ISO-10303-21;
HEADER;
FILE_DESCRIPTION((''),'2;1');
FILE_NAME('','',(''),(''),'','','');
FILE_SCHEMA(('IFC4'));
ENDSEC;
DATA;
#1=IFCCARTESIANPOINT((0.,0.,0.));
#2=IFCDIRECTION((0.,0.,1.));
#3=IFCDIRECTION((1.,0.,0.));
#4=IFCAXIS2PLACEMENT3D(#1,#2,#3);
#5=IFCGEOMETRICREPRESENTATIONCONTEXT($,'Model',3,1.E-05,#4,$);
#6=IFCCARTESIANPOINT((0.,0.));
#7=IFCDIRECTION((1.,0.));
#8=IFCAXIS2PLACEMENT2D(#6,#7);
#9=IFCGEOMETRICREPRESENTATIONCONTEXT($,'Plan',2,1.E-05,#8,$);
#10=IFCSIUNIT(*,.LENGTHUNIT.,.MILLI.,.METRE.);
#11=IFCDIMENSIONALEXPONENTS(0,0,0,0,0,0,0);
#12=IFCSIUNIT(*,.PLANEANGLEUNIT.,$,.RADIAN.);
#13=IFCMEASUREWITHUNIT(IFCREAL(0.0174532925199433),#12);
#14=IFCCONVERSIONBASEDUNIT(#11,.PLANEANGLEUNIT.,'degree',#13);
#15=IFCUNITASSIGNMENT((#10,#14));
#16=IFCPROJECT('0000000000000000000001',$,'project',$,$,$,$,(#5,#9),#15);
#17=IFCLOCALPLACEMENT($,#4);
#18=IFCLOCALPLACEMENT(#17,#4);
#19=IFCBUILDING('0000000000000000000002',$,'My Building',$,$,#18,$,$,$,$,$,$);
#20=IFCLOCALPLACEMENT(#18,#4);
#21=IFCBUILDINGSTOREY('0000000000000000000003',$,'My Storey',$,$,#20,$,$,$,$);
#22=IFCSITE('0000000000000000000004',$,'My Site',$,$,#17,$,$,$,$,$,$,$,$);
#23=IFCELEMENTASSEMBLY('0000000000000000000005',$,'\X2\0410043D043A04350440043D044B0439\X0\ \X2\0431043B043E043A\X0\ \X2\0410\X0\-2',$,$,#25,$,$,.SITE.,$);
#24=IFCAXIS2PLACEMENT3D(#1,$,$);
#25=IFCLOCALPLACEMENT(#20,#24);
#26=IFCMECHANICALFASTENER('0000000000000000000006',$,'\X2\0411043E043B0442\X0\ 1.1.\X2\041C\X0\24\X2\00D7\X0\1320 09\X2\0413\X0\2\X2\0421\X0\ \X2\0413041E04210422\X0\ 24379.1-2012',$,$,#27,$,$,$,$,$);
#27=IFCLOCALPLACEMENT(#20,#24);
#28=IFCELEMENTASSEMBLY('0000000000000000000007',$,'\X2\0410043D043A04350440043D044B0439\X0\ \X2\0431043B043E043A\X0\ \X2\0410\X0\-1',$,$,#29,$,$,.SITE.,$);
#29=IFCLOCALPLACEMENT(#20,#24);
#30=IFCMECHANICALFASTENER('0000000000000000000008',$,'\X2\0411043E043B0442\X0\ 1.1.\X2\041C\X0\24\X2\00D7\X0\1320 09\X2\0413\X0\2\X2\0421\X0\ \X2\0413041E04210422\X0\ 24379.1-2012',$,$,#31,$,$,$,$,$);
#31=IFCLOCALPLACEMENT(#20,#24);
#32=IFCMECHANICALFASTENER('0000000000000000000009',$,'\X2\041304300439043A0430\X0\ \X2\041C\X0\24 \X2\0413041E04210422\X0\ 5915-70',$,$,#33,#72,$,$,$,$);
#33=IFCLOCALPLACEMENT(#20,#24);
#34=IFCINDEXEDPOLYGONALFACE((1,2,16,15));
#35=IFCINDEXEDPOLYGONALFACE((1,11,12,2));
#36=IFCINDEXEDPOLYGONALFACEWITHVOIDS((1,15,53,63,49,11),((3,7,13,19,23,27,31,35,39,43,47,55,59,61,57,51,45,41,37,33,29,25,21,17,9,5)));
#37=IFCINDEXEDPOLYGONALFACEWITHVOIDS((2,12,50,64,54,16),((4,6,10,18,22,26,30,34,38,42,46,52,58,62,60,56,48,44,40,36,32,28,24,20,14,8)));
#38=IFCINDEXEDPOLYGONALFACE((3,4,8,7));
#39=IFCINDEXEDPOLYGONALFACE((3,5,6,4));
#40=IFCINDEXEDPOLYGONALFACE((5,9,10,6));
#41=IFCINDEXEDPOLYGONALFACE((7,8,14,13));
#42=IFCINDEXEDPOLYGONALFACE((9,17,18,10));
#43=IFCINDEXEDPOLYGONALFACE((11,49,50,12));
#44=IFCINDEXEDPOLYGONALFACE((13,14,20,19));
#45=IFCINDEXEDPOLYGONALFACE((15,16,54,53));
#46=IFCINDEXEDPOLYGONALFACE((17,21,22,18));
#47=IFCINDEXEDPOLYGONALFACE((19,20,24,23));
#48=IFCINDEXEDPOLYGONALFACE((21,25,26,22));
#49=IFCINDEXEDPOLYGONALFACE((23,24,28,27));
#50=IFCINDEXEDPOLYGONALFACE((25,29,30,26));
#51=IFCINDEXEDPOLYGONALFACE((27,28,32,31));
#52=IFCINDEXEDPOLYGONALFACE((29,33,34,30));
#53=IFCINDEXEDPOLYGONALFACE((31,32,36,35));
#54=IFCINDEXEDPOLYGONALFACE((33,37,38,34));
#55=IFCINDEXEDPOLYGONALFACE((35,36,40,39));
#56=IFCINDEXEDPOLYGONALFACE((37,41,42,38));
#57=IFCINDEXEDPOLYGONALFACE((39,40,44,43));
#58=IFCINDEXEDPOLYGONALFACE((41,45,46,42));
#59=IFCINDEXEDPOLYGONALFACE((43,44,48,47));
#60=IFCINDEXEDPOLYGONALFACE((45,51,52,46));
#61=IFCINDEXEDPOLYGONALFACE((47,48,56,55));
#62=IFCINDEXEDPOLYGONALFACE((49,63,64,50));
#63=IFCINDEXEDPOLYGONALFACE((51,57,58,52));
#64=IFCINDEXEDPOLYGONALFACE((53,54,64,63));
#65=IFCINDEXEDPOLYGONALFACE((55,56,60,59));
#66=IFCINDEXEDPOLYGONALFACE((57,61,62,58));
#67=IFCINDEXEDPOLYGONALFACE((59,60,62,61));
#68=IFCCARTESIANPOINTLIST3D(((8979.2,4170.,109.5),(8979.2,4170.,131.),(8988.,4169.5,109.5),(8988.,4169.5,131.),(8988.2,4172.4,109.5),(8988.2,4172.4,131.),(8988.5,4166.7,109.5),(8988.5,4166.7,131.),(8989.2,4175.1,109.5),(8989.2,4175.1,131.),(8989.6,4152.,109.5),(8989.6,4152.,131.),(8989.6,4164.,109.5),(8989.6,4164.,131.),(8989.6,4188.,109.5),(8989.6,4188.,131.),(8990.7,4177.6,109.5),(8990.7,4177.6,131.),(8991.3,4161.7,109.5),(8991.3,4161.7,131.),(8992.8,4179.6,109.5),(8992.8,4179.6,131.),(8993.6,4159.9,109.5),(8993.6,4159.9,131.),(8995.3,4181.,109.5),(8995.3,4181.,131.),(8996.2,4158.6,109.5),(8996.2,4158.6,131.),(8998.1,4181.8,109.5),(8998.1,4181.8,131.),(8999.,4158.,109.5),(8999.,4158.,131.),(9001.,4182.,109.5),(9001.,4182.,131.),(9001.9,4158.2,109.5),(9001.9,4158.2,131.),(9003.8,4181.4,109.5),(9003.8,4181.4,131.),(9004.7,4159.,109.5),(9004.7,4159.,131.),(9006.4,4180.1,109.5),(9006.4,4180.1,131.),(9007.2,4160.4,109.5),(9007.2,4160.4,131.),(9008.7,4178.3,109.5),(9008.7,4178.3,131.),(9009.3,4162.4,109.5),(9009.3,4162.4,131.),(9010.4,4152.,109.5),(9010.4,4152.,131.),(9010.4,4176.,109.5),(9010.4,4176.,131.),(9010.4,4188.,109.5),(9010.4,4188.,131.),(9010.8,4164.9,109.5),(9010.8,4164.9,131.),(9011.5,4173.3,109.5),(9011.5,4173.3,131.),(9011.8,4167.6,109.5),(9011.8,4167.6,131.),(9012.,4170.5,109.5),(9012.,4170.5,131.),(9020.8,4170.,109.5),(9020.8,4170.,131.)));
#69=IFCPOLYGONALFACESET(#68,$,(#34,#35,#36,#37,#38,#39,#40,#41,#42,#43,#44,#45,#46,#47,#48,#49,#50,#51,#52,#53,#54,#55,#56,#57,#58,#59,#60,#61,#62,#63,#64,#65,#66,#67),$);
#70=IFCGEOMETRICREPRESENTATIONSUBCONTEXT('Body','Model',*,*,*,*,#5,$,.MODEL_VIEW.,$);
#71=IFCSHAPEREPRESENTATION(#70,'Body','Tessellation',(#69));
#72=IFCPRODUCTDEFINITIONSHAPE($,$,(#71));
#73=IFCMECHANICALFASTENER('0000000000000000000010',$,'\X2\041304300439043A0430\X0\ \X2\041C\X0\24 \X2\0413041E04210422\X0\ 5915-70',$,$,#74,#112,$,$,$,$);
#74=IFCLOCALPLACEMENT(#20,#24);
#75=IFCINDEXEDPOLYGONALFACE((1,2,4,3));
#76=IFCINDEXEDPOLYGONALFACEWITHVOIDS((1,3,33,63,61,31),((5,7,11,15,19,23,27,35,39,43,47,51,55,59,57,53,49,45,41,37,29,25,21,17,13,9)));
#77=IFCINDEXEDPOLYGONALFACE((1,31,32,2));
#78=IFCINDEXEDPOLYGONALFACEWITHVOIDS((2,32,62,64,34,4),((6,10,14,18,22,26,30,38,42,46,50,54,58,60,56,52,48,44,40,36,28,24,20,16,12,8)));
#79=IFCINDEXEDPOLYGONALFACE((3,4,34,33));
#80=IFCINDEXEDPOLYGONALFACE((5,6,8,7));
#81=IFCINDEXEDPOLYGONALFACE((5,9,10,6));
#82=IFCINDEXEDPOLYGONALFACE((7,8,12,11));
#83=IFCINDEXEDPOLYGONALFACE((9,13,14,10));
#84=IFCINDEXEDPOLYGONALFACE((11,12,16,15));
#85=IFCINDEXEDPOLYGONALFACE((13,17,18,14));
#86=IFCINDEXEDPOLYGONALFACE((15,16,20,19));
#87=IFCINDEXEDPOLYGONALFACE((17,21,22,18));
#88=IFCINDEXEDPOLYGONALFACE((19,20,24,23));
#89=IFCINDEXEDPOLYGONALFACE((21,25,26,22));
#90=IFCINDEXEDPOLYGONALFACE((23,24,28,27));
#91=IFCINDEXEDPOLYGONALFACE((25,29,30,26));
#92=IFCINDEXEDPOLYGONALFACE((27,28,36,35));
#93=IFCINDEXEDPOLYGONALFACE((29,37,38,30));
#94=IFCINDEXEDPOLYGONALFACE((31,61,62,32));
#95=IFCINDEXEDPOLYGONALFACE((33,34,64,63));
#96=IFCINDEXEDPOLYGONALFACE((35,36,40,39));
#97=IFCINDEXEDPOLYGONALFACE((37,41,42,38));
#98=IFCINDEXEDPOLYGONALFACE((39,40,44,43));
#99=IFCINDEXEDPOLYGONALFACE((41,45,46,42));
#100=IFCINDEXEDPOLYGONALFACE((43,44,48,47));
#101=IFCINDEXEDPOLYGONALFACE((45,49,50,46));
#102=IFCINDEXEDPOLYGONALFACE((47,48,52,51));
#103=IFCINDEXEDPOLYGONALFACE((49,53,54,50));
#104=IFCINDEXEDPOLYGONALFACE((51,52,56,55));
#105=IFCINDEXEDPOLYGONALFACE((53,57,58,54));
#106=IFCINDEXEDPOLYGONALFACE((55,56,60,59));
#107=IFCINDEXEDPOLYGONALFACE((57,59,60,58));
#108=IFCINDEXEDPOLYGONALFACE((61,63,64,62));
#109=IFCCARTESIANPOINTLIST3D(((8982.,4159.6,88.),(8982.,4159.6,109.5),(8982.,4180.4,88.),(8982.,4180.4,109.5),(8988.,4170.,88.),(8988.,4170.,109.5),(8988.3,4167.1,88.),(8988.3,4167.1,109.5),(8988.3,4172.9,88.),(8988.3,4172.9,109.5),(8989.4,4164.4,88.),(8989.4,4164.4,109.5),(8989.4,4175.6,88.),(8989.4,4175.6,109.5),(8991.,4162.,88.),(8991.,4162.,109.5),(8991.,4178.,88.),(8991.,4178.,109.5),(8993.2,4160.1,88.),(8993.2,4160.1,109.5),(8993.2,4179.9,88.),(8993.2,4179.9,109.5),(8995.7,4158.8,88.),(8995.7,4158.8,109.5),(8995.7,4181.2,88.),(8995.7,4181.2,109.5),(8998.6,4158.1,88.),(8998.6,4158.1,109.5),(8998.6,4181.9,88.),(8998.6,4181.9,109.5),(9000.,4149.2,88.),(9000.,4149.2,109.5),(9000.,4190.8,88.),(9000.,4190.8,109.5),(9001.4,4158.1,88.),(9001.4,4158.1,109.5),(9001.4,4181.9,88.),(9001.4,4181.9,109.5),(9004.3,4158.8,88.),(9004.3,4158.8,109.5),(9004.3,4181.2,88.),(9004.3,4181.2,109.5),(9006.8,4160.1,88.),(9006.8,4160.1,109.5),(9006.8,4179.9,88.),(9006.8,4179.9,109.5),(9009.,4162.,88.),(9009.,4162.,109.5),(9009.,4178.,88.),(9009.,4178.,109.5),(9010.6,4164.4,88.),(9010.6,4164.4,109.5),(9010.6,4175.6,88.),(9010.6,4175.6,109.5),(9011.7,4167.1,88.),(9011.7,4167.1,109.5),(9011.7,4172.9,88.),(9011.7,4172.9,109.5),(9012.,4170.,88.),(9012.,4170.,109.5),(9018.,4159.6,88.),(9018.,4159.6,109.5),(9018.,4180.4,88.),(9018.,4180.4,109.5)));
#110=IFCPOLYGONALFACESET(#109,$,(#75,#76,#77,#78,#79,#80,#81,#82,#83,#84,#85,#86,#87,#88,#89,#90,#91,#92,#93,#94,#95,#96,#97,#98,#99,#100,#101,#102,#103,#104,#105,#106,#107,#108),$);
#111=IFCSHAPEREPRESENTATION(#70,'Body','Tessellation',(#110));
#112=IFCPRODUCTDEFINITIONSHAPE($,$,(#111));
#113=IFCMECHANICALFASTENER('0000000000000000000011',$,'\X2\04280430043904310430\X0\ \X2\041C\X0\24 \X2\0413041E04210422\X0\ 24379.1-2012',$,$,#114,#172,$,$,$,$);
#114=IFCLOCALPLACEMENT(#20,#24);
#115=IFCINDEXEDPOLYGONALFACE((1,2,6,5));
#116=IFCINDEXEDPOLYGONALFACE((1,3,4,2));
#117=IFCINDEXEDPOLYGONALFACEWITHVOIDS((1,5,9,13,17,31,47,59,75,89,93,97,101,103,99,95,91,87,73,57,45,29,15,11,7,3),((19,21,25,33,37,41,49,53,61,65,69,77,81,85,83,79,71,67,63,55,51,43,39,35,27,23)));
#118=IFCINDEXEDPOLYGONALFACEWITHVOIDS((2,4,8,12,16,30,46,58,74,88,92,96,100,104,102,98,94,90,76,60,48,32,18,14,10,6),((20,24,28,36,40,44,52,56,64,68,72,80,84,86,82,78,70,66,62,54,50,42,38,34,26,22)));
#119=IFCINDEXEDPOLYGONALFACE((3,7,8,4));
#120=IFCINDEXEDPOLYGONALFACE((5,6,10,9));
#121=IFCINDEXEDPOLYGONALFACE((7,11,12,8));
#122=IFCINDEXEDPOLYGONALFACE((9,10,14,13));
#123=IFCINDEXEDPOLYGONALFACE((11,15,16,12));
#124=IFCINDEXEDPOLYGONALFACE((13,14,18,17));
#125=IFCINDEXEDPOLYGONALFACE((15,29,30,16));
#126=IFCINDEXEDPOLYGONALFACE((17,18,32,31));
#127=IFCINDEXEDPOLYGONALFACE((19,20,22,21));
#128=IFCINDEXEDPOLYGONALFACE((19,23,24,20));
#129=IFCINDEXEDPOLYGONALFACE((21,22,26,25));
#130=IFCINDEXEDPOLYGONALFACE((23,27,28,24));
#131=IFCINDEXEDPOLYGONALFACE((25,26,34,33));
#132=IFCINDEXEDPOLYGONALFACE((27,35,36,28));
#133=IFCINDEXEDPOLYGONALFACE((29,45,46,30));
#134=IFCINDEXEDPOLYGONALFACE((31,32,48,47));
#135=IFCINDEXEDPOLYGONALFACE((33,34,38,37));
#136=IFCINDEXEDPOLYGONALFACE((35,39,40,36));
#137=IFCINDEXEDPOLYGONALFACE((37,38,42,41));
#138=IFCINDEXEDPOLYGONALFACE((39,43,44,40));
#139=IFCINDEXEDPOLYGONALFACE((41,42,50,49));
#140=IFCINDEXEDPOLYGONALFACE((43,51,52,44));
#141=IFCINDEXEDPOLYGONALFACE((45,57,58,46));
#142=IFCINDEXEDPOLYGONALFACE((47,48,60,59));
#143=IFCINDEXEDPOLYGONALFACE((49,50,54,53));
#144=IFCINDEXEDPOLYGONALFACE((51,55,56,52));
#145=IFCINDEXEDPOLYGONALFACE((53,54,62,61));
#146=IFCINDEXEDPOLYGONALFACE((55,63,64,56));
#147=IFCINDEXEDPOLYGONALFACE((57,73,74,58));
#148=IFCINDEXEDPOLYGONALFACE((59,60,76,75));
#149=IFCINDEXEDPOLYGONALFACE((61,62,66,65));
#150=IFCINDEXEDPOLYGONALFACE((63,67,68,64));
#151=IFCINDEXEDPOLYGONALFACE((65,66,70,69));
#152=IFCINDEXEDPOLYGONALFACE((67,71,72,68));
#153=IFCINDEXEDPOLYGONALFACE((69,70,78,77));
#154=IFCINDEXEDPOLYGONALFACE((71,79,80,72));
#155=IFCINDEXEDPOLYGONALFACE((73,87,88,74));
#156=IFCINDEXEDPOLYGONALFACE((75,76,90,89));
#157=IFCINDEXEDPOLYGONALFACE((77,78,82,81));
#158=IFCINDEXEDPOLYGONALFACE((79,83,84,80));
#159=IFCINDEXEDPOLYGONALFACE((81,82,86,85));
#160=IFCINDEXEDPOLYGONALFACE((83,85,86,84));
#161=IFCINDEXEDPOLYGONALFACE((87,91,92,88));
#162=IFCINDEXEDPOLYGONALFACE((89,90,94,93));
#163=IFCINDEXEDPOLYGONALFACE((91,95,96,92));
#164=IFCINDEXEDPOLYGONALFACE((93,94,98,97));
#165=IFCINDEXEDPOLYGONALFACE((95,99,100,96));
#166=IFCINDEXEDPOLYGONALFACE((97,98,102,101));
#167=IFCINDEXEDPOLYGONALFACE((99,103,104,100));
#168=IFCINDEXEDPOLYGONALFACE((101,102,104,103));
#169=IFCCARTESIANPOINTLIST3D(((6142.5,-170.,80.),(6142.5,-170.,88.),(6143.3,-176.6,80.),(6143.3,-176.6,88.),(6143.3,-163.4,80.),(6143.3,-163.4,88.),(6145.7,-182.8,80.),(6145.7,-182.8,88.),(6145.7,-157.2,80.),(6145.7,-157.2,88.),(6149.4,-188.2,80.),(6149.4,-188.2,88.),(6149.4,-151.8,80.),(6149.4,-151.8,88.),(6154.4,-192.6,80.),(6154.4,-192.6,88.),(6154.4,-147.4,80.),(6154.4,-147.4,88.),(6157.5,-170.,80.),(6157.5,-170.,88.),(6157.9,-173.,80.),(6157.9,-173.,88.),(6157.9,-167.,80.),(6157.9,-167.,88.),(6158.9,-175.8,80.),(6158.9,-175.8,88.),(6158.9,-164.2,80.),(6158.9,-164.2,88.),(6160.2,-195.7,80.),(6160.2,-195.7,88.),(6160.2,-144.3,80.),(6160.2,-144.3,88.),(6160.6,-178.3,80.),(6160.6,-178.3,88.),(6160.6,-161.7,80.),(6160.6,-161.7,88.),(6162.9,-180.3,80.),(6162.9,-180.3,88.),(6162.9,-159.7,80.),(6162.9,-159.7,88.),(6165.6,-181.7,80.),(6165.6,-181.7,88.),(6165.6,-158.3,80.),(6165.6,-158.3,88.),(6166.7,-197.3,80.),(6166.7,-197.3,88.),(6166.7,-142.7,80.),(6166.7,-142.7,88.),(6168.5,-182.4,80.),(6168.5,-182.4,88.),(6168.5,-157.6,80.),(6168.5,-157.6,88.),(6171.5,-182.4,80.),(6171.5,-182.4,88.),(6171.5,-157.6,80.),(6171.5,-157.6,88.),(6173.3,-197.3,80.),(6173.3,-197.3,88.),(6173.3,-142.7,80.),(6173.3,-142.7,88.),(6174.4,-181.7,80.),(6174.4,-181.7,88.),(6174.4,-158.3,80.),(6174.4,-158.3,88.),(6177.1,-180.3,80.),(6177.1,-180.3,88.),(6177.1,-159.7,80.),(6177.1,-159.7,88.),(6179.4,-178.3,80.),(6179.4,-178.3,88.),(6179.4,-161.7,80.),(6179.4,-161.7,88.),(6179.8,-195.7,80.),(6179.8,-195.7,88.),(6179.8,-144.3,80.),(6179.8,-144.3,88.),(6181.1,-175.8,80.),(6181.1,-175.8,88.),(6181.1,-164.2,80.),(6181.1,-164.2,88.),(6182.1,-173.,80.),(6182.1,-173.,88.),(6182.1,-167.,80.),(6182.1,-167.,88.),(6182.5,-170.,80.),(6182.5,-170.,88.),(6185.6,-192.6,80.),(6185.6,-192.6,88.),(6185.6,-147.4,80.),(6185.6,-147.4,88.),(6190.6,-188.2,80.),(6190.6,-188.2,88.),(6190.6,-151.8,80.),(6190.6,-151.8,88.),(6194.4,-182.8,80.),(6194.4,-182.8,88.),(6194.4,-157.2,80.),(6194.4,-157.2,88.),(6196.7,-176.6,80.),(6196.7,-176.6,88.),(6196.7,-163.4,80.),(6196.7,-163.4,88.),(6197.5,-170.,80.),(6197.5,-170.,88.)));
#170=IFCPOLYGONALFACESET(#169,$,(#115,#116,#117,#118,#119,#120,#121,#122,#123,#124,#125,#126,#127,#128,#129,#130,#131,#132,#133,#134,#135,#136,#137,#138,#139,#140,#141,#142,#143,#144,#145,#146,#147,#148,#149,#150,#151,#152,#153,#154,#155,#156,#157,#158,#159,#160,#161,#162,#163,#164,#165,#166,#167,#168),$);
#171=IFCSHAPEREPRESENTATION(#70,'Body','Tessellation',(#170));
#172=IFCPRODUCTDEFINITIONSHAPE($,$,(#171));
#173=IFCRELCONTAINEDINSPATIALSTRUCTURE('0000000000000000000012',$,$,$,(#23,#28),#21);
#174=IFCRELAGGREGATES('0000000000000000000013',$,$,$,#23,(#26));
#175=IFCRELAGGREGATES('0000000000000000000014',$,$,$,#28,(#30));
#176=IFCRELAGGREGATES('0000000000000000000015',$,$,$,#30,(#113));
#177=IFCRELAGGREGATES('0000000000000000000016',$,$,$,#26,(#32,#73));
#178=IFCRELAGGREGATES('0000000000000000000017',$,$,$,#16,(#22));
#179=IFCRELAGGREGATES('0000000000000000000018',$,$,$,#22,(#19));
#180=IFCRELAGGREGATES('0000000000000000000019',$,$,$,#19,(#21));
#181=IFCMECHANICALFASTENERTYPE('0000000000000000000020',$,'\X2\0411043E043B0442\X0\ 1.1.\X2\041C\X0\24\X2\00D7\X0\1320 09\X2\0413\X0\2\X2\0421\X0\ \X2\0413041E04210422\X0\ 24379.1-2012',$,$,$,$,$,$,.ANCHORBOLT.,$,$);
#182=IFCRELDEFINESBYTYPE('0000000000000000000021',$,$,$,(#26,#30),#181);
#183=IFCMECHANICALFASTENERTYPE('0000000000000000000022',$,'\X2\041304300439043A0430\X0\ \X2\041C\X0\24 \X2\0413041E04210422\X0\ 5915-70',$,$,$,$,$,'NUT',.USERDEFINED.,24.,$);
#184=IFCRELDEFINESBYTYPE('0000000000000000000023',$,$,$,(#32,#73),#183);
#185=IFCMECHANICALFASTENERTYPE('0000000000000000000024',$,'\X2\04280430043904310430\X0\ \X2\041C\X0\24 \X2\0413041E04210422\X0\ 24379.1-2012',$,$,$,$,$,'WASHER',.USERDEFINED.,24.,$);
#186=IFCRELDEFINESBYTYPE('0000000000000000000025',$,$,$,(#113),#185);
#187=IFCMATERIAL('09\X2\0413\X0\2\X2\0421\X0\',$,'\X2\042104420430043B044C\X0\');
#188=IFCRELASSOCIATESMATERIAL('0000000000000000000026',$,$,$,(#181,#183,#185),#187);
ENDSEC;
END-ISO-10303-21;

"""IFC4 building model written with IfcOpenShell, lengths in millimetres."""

from ifc_helpers import new_model, entity, si_unit, converted_unit, frame, origin_with_axes, origin_2d_with_axis, place, context, subcontext, project, spatial, polyline, outline, extrude, source, transform, mapped, material, type_object, type_shapes, element, aggregate, save


model = new_model("IFC4")

# Units and contexts
model_context = context("Model", 3, precision=1e-05, world=origin_with_axes())
plan_context = context("Plan", 2, precision=1e-05, world=origin_2d_with_axis())
body_context = subcontext(model_context, "Body", "Model", "MODEL_VIEW")
ifc_project = project(units=[si_unit("LENGTHUNIT", "METRE", prefix="MILLI"), converted_unit("PLANEANGLEUNIT", "degree", entity("IfcReal", 0.0174532925199433), si_unit("PLANEANGLEUNIT", "RADIAN"), dimensions=[0, 0, 0, 0, 0, 0, 0])], contexts=[model_context, plan_context])

# Site, building, storey
site_placement = place(None, origin_with_axes())
site = spatial("IfcSite", under=ifc_project, at=site_placement, Name="My Site")
building_placement = place(site_placement, origin_with_axes())
building = spatial("IfcBuilding", under=site, at=building_placement, Name="My Building")
storey_placement = place(building_placement, origin_with_axes())
storey = spatial("IfcBuildingStorey", under=building, at=storey_placement, Name="My Storey")

# Element assemblies, mechanical fasteners
ifc_material_1 = material(Name="09Г2С", Category="Сталь")
mechanical_fastener_type_1 = type_object("IfcMechanicalFastenerType", Name="Болт 1.1.М24×1320 09Г2С ГОСТ 24379.1-2012", PredefinedType="ANCHORBOLT", material=ifc_material_1)
assembly_1_placement = place(storey_placement, frame((9000.0, 4000.0, 0.0), z_axis=(0.0, 0.0, 1.0), x_axis=(1.0, 0.0, 0.0)))
assembly_1 = element("IfcElementAssembly", 1, at=assembly_1_placement, inside=storey, Name="Анкерный блок А-2", AssemblyPlace="SITE")
mechanical_fastener_1_placement = place(assembly_1_placement, frame((0.0, 170.0, 0.0), z_axis=(0.0, 0.0, 1.0), x_axis=(-1.0, 0.0, 0.0)))
mechanical_fastener_1 = element("IfcMechanicalFastener", 2, at=mechanical_fastener_1_placement, type_object=mechanical_fastener_type_1, Name="Болт 1.1.М24×1320 09Г2С ГОСТ 24379.1-2012")
aggregate(assembly_1, [mechanical_fastener_1])
assembly_2_placement = place(storey_placement, frame((6000.0, 0.0, 0.0), z_axis=(0.0, 0.0, 1.0), x_axis=(1.0, 0.0, 0.0)))
assembly_2 = element("IfcElementAssembly", 3, at=assembly_2_placement, inside=storey, Name="Анкерный блок А-1", AssemblyPlace="SITE")
mechanical_fastener_2_placement = place(assembly_2_placement, frame((170.0, -170.0, 0.0), z_axis=(0.0, 0.0, 1.0), x_axis=(1.0, 0.0, 0.0)))
mechanical_fastener_2 = element("IfcMechanicalFastener", 4, at=mechanical_fastener_2_placement, type_object=mechanical_fastener_type_1, Name="Болт 1.1.М24×1320 09Г2С ГОСТ 24379.1-2012")
aggregate(assembly_2, [mechanical_fastener_2])
mechanical_fastener_type_2 = type_object("IfcMechanicalFastenerType", Name="Гайка М24 ГОСТ 5915-70", ElementType="NUT", NominalDiameter=24.0, PredefinedType="USERDEFINED", material=ifc_material_1)
shared_shape_1 = source(origin_with_axes(), body_context, "Body", "SweptSolid", [
    extrude(outline(polyline([(-10.4, -18.0), (10.4, -18.0), (20.8, 0.0), (10.4, 18.0), (-10.4, 18.0), (-20.8, 0.0), (-10.4, -18.0)]), holes=[polyline([(-8.0, 9.0), (-5.6, 10.6), (-2.9, 11.7), (0.0, 12.0), (2.9, 11.7), (5.6, 10.6), (8.0, 9.0), (9.9, 6.8), (11.2, 4.3), (11.9, 1.4), (11.9, -1.4), (11.2, -4.3), (9.9, -6.8), (8.0, -9.0), (5.6, -10.6), (2.9, -11.7), (0.0, -12.0), (-2.9, -11.7), (-5.6, -10.6), (-8.0, -9.0), (-9.9, -6.8), (-11.2, -4.3), (-11.9, -1.4), (-11.9, 1.4), (-11.2, 4.3), (-9.9, 6.8), (-8.0, 9.0)])]), frame((0.0, 0.0, 0.0), z_axis=(0.0, 0.0, 1.0), x_axis=(0.0, 1.0, 0.0)), (0.0, 0.0, 1.0), 21.5),
])
type_shapes(mechanical_fastener_type_2, [shared_shape_1])

# Mechanical fasteners
mechanical_fastener_3_placement = place(mechanical_fastener_1_placement, frame((0.0, 0.0, 109.5), z_axis=(0.0, 0.0, 1.0), x_axis=(0.866025, 0.5, 0.0)))
mechanical_fastener_3 = element("IfcMechanicalFastener", 5, at=mechanical_fastener_3_placement, type_object=mechanical_fastener_type_2, Name="Гайка М24 ГОСТ 5915-70", context=body_context, shape_type="MappedRepresentation", body=[
    mapped(shared_shape_1, transform((0.0, 0.0, 0.0), x_axis=(1.0, 0.0, 0.0), y_axis=(0.0, 1.0, 0.0), z_axis=(0.0, 0.0, 1.0), scale=1.0)),
])
mechanical_fastener_4_placement = place(mechanical_fastener_1_placement, frame((0.0, 0.0, 88.0), z_axis=(0.0, 0.0, 1.0), x_axis=(1.0, 0.0, 0.0)))
mechanical_fastener_4 = element("IfcMechanicalFastener", 6, at=mechanical_fastener_4_placement, type_object=mechanical_fastener_type_2, Name="Гайка М24 ГОСТ 5915-70", context=body_context, shape_type="MappedRepresentation", body=[
    mapped(shared_shape_1, transform((0.0, 0.0, 0.0), x_axis=(1.0, 0.0, 0.0), y_axis=(0.0, 1.0, 0.0), z_axis=(0.0, 0.0, 1.0), scale=1.0)),
])
mechanical_fastener_type_3 = type_object("IfcMechanicalFastenerType", Name="Шайба М24 ГОСТ 24379.1-2012", ElementType="WASHER", NominalDiameter=24.0, PredefinedType="USERDEFINED", material=ifc_material_1)
shared_shape_2 = source(origin_with_axes(), body_context, "Body", "SweptSolid", [
    extrude(outline(polyline([(27.5, 0.0), (26.7, 6.6), (24.4, 12.8), (20.6, 18.2), (15.6, 22.6), (9.8, 25.7), (3.3, 27.3), (-3.3, 27.3), (-9.8, 25.7), (-15.6, 22.6), (-20.6, 18.2), (-24.4, 12.8), (-26.7, 6.6), (-27.5, 0.0), (-26.7, -6.6), (-24.4, -12.8), (-20.6, -18.2), (-15.6, -22.6), (-9.8, -25.7), (-3.3, -27.3), (3.3, -27.3), (9.8, -25.7), (15.6, -22.6), (20.6, -18.2), (24.4, -12.8), (26.7, -6.6), (27.5, 0.0)]), holes=[polyline([(-4.4, -11.7), (-7.1, -10.3), (-9.4, -8.3), (-11.1, -5.8), (-12.1, -3.0), (-12.5, 0.0), (-12.1, 3.0), (-11.1, 5.8), (-9.4, 8.3), (-7.1, 10.3), (-4.4, 11.7), (-1.5, 12.4), (1.5, 12.4), (4.4, 11.7), (7.1, 10.3), (9.4, 8.3), (11.1, 5.8), (12.1, 3.0), (12.5, 0.0), (12.1, -3.0), (11.1, -5.8), (9.4, -8.3), (7.1, -10.3), (4.4, -11.7), (1.5, -12.4), (-1.5, -12.4), (-4.4, -11.7)])]), frame((0.0, 0.0, 0.0), z_axis=(0.0, 0.0, 1.0), x_axis=(0.120537, -0.992709, 0.0)), (0.0, 0.0, 1.0), 8.0),
])
type_shapes(mechanical_fastener_type_3, [shared_shape_2])
mechanical_fastener_5_placement = place(mechanical_fastener_2_placement, frame((0.0, 0.0, 80.0), z_axis=(0.0, 0.0, 1.0), x_axis=(1.0, 0.0, 0.0)))
mechanical_fastener_5 = element("IfcMechanicalFastener", 7, at=mechanical_fastener_5_placement, type_object=mechanical_fastener_type_3, Name="Шайба М24 ГОСТ 24379.1-2012", context=body_context, shape_type="MappedRepresentation", body=[
    mapped(shared_shape_2, transform((0.0, 0.0, 0.0), x_axis=(1.0, 0.0, 0.0), y_axis=(0.0, 1.0, 0.0), z_axis=(0.0, 0.0, 1.0), scale=1.0)),
])
aggregate(mechanical_fastener_2, [mechanical_fastener_5])
aggregate(mechanical_fastener_1, [mechanical_fastener_3, mechanical_fastener_4])

save(model, "model.ifc")
